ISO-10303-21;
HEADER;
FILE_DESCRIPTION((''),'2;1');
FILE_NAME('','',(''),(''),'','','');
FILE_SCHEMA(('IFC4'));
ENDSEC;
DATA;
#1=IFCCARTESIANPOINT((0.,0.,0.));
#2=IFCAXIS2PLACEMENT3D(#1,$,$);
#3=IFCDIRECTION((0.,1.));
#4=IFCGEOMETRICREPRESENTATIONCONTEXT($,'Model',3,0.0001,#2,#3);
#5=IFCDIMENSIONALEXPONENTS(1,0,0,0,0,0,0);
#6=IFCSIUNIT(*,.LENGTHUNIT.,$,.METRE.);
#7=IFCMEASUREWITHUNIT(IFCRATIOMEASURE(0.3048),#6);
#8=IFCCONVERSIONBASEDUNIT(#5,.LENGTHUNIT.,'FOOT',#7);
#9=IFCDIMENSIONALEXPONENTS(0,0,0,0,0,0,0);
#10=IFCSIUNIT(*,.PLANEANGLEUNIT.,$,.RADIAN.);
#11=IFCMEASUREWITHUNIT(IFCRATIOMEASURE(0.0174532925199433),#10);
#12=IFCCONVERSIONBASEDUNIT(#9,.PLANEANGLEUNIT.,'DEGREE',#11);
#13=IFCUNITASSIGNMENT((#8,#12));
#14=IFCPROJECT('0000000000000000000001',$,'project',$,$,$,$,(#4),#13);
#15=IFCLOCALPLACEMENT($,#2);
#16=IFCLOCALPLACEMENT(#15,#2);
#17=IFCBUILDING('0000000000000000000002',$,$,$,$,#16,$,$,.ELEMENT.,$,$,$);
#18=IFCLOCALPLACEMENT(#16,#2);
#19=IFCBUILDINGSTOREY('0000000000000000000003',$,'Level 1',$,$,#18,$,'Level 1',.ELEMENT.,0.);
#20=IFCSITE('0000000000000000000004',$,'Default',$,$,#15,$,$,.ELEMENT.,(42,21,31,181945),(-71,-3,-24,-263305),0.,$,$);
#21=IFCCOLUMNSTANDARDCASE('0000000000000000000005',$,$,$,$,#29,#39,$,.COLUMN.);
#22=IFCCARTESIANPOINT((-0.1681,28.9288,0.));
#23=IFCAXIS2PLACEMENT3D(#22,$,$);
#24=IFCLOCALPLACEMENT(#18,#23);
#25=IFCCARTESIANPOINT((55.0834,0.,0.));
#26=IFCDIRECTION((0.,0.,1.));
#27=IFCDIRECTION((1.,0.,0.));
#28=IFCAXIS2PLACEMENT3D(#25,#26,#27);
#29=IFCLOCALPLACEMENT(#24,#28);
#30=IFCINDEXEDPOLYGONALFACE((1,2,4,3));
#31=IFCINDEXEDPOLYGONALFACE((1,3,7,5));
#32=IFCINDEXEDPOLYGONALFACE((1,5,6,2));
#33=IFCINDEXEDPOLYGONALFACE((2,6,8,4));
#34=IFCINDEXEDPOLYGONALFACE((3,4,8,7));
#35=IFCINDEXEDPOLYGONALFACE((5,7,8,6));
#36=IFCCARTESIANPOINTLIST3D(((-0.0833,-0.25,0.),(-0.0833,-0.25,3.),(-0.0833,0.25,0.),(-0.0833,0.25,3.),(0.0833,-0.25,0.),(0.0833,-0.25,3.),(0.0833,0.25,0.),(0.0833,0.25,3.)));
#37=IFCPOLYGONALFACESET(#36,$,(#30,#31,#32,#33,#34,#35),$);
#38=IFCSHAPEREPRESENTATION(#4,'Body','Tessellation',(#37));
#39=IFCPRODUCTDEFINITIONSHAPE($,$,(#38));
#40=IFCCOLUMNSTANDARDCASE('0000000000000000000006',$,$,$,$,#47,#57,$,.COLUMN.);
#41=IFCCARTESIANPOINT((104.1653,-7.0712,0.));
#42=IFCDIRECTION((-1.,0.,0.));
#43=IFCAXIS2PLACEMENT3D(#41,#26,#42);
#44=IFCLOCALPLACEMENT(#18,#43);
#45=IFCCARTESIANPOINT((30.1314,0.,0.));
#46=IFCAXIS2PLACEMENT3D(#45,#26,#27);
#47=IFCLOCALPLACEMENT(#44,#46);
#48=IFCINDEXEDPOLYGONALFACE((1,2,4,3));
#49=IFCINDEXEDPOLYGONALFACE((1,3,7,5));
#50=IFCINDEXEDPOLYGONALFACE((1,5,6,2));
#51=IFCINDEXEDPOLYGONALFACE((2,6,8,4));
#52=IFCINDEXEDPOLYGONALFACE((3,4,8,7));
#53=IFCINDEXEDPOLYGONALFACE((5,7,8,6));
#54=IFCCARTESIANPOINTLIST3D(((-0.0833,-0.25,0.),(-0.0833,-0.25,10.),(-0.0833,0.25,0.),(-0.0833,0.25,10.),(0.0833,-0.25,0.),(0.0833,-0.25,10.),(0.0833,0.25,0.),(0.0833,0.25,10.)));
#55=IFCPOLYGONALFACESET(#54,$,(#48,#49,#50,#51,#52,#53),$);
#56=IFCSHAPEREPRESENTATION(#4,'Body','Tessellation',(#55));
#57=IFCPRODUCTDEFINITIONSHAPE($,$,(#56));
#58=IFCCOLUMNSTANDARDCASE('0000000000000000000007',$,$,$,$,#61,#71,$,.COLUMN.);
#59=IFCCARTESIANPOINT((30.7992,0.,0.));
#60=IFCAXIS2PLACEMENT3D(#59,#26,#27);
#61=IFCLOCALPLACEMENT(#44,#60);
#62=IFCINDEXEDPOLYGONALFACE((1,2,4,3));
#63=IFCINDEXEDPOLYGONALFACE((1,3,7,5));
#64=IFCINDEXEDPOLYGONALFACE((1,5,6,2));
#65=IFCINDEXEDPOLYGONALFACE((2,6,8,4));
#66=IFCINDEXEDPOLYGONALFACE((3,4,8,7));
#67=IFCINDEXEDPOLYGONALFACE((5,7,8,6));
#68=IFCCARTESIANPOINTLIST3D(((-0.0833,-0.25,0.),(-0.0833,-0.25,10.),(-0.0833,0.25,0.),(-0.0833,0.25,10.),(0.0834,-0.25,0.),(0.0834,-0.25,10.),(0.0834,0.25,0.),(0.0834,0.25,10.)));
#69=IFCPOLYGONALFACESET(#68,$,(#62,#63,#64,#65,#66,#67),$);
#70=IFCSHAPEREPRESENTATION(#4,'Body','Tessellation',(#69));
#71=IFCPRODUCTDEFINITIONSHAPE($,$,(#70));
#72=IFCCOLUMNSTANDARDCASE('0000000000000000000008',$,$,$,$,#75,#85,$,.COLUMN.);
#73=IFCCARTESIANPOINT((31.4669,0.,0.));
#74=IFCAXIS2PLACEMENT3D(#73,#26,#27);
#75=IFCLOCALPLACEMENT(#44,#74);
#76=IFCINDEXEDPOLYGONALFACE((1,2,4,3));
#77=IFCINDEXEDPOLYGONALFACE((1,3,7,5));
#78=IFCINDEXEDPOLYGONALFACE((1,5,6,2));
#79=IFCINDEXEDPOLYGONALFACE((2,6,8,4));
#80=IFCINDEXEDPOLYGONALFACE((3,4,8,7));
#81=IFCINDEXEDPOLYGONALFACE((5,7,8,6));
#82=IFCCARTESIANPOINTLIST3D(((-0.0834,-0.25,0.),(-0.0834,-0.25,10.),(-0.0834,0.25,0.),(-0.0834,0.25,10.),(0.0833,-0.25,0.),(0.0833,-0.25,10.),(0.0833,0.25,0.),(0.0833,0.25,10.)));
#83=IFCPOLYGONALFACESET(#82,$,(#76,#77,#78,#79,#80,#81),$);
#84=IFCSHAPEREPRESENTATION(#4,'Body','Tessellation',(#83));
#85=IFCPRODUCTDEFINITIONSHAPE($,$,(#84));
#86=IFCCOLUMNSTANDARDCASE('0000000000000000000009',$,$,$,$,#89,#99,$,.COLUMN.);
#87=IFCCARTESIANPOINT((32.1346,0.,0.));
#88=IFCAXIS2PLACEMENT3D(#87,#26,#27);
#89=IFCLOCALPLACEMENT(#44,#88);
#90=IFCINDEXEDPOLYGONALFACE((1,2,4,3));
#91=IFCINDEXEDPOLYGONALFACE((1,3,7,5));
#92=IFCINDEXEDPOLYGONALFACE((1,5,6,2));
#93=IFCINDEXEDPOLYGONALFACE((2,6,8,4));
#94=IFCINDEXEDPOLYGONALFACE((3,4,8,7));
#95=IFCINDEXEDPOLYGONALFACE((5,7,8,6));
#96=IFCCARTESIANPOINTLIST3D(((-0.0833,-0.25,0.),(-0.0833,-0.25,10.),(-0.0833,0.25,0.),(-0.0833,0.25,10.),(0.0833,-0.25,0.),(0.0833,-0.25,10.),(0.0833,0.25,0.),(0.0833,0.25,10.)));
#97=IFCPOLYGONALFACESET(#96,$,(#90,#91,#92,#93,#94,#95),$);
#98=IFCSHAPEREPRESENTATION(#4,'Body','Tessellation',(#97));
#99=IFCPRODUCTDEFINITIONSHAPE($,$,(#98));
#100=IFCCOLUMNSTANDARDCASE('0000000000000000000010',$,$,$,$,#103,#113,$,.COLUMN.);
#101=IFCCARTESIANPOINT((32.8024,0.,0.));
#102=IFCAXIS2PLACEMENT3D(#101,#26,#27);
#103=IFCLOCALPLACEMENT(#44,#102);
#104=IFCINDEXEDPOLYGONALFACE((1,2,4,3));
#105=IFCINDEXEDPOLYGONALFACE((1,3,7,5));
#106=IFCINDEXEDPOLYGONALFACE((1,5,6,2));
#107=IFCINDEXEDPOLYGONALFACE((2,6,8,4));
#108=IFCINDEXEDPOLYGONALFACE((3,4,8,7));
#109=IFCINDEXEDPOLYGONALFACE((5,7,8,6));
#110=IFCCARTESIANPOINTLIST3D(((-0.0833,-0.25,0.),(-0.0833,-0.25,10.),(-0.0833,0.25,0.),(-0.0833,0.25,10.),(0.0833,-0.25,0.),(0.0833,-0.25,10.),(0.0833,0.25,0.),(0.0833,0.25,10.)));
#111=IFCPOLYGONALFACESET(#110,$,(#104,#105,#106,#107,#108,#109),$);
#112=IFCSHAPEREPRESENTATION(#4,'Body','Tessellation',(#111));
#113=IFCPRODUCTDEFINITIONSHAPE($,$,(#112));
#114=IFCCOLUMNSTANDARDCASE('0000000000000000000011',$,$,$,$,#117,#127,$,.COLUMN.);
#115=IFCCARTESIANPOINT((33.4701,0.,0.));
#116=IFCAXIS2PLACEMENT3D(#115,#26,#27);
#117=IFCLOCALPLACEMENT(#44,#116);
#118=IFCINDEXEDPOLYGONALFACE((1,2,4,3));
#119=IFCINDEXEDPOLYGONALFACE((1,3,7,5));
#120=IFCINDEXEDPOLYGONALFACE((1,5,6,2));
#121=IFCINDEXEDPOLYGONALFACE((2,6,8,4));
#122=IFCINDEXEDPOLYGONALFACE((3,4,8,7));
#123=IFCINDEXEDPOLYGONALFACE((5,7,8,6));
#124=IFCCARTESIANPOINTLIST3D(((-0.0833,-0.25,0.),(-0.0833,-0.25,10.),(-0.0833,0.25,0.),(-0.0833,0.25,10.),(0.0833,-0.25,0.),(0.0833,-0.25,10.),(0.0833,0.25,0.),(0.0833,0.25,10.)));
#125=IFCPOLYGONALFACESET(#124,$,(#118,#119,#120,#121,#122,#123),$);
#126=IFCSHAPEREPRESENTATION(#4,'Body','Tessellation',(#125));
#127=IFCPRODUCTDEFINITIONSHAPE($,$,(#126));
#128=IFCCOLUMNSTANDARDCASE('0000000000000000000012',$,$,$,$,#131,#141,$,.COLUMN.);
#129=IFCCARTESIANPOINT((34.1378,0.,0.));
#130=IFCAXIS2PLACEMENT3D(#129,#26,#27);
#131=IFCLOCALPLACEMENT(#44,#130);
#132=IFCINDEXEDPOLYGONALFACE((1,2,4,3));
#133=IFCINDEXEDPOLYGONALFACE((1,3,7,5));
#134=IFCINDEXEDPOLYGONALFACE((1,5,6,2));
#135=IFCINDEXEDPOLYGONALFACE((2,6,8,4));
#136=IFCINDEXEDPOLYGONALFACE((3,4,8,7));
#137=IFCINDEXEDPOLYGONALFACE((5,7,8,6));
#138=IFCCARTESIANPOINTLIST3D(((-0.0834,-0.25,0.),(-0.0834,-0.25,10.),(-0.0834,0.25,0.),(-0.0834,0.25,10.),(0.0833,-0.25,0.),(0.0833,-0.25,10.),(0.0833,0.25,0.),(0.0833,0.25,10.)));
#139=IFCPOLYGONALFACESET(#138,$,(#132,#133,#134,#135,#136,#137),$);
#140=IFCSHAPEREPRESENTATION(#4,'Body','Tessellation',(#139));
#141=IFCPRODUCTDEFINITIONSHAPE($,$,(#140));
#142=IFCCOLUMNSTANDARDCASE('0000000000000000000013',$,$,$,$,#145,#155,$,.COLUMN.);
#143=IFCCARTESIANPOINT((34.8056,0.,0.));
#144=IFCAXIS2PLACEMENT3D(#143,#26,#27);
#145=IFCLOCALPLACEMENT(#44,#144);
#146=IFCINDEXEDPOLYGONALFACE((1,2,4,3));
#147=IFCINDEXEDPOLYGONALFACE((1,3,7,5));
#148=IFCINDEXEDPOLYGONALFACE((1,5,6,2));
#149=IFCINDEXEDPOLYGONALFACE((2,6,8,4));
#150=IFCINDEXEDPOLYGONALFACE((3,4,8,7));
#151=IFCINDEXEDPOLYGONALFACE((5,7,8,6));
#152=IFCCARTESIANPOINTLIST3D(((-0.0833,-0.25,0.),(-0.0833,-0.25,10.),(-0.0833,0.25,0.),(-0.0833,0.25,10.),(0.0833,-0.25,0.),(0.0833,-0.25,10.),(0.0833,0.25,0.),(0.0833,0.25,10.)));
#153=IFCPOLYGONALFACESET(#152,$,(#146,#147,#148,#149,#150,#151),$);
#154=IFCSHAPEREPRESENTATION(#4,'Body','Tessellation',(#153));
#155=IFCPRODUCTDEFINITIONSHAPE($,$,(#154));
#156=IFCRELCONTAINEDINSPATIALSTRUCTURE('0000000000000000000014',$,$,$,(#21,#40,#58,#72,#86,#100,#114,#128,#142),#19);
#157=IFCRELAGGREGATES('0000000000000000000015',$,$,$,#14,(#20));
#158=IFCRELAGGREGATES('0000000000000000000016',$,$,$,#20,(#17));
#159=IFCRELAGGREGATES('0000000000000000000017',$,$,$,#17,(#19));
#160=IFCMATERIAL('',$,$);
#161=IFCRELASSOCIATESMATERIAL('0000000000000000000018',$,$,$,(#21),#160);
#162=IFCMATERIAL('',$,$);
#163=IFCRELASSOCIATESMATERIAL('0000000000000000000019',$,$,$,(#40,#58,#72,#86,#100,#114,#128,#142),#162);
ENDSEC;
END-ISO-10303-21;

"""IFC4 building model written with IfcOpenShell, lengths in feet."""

from ifc_helpers import new_model, entity, si_unit, converted_unit, direction, frame, origin, place, context, project, spatial, rectangle, extrude, material, element, save


model = new_model("IFC4")

# Units and contexts
model_context = context("Model", 3, precision=0.0001, world=origin(), true_north=direction((0.0, 1.0)))
ifc_project = project(units=[converted_unit("LENGTHUNIT", "FOOT", entity("IfcRatioMeasure", 0.3048), si_unit("LENGTHUNIT", "METRE"), dimensions=[1, 0, 0, 0, 0, 0, 0]), converted_unit("PLANEANGLEUNIT", "DEGREE", entity("IfcRatioMeasure", 0.0174532925199433), si_unit("PLANEANGLEUNIT", "RADIAN"), dimensions=[0, 0, 0, 0, 0, 0, 0])], contexts=[model_context])

# Site, building, storey
site_placement = place(None, origin())
site = spatial("IfcSite", under=ifc_project, at=site_placement, Name="Default", CompositionType="ELEMENT", RefLatitude=(42, 21, 31, 181945), RefLongitude=(-71, -3, -24, -263305), RefElevation=0.0)
building_placement = place(site_placement, origin())
building = spatial("IfcBuilding", under=site, at=building_placement, CompositionType="ELEMENT")
storey_placement = place(building_placement, origin())
storey = spatial("IfcBuildingStorey", under=building, at=storey_placement, Name="Level 1", LongName="Level 1", CompositionType="ELEMENT", Elevation=0.0)

# Columns
placement_1 = place(storey_placement, frame((-0.1681, 28.9288, 0.0)))
ifc_material_1 = material(Name="")
for number, where, z_axis, x_axis in (
    (1, (55.0834, 0.0, 0.0), (0.0, 0.0, 1.0), (1.0, 0.0, 0.0)),
):
    element("IfcColumnStandardCase", number, at=place(placement_1, frame(where, z_axis=z_axis, x_axis=x_axis)), inside=storey, material=ifc_material_1, PredefinedType="COLUMN", context=model_context, shape_type="SweptSolid", body=[
        extrude(rectangle(XDim=0.1667, YDim=0.5), origin(), (0.0, 0.0, 1.0), 3.0),
    ])
ifc_material_2 = material(Name="")
placement_2 = place(storey_placement, frame((104.1653, -7.0712, 0.0), z_axis=(0.0, 0.0, 1.0), x_axis=(-1.0, 0.0, 0.0)))
for number, where, z_axis, x_axis in (
    (2, (30.1314, 0.0, 0.0), (0.0, 0.0, 1.0), (1.0, 0.0, 0.0)),
    (3, (30.7992, 0.0, 0.0), (0.0, 0.0, 1.0), (1.0, 0.0, 0.0)),
    (4, (31.4669, 0.0, 0.0), (0.0, 0.0, 1.0), (1.0, 0.0, 0.0)),
    (5, (32.1346, 0.0, 0.0), (0.0, 0.0, 1.0), (1.0, 0.0, 0.0)),
    (6, (32.8024, 0.0, 0.0), (0.0, 0.0, 1.0), (1.0, 0.0, 0.0)),
    (7, (33.4701, 0.0, 0.0), (0.0, 0.0, 1.0), (1.0, 0.0, 0.0)),
    (8, (34.1378, 0.0, 0.0), (0.0, 0.0, 1.0), (1.0, 0.0, 0.0)),
    (9, (34.8056, 0.0, 0.0), (0.0, 0.0, 1.0), (1.0, 0.0, 0.0)),
):
    element("IfcColumnStandardCase", number, at=place(placement_2, frame(where, z_axis=z_axis, x_axis=x_axis)), inside=storey, material=ifc_material_2, PredefinedType="COLUMN", context=model_context, shape_type="SweptSolid", body=[
        extrude(rectangle(XDim=0.1667, YDim=0.5), origin(), (0.0, 0.0, 1.0), 10.0),
    ])

save(model, "model.ifc")
